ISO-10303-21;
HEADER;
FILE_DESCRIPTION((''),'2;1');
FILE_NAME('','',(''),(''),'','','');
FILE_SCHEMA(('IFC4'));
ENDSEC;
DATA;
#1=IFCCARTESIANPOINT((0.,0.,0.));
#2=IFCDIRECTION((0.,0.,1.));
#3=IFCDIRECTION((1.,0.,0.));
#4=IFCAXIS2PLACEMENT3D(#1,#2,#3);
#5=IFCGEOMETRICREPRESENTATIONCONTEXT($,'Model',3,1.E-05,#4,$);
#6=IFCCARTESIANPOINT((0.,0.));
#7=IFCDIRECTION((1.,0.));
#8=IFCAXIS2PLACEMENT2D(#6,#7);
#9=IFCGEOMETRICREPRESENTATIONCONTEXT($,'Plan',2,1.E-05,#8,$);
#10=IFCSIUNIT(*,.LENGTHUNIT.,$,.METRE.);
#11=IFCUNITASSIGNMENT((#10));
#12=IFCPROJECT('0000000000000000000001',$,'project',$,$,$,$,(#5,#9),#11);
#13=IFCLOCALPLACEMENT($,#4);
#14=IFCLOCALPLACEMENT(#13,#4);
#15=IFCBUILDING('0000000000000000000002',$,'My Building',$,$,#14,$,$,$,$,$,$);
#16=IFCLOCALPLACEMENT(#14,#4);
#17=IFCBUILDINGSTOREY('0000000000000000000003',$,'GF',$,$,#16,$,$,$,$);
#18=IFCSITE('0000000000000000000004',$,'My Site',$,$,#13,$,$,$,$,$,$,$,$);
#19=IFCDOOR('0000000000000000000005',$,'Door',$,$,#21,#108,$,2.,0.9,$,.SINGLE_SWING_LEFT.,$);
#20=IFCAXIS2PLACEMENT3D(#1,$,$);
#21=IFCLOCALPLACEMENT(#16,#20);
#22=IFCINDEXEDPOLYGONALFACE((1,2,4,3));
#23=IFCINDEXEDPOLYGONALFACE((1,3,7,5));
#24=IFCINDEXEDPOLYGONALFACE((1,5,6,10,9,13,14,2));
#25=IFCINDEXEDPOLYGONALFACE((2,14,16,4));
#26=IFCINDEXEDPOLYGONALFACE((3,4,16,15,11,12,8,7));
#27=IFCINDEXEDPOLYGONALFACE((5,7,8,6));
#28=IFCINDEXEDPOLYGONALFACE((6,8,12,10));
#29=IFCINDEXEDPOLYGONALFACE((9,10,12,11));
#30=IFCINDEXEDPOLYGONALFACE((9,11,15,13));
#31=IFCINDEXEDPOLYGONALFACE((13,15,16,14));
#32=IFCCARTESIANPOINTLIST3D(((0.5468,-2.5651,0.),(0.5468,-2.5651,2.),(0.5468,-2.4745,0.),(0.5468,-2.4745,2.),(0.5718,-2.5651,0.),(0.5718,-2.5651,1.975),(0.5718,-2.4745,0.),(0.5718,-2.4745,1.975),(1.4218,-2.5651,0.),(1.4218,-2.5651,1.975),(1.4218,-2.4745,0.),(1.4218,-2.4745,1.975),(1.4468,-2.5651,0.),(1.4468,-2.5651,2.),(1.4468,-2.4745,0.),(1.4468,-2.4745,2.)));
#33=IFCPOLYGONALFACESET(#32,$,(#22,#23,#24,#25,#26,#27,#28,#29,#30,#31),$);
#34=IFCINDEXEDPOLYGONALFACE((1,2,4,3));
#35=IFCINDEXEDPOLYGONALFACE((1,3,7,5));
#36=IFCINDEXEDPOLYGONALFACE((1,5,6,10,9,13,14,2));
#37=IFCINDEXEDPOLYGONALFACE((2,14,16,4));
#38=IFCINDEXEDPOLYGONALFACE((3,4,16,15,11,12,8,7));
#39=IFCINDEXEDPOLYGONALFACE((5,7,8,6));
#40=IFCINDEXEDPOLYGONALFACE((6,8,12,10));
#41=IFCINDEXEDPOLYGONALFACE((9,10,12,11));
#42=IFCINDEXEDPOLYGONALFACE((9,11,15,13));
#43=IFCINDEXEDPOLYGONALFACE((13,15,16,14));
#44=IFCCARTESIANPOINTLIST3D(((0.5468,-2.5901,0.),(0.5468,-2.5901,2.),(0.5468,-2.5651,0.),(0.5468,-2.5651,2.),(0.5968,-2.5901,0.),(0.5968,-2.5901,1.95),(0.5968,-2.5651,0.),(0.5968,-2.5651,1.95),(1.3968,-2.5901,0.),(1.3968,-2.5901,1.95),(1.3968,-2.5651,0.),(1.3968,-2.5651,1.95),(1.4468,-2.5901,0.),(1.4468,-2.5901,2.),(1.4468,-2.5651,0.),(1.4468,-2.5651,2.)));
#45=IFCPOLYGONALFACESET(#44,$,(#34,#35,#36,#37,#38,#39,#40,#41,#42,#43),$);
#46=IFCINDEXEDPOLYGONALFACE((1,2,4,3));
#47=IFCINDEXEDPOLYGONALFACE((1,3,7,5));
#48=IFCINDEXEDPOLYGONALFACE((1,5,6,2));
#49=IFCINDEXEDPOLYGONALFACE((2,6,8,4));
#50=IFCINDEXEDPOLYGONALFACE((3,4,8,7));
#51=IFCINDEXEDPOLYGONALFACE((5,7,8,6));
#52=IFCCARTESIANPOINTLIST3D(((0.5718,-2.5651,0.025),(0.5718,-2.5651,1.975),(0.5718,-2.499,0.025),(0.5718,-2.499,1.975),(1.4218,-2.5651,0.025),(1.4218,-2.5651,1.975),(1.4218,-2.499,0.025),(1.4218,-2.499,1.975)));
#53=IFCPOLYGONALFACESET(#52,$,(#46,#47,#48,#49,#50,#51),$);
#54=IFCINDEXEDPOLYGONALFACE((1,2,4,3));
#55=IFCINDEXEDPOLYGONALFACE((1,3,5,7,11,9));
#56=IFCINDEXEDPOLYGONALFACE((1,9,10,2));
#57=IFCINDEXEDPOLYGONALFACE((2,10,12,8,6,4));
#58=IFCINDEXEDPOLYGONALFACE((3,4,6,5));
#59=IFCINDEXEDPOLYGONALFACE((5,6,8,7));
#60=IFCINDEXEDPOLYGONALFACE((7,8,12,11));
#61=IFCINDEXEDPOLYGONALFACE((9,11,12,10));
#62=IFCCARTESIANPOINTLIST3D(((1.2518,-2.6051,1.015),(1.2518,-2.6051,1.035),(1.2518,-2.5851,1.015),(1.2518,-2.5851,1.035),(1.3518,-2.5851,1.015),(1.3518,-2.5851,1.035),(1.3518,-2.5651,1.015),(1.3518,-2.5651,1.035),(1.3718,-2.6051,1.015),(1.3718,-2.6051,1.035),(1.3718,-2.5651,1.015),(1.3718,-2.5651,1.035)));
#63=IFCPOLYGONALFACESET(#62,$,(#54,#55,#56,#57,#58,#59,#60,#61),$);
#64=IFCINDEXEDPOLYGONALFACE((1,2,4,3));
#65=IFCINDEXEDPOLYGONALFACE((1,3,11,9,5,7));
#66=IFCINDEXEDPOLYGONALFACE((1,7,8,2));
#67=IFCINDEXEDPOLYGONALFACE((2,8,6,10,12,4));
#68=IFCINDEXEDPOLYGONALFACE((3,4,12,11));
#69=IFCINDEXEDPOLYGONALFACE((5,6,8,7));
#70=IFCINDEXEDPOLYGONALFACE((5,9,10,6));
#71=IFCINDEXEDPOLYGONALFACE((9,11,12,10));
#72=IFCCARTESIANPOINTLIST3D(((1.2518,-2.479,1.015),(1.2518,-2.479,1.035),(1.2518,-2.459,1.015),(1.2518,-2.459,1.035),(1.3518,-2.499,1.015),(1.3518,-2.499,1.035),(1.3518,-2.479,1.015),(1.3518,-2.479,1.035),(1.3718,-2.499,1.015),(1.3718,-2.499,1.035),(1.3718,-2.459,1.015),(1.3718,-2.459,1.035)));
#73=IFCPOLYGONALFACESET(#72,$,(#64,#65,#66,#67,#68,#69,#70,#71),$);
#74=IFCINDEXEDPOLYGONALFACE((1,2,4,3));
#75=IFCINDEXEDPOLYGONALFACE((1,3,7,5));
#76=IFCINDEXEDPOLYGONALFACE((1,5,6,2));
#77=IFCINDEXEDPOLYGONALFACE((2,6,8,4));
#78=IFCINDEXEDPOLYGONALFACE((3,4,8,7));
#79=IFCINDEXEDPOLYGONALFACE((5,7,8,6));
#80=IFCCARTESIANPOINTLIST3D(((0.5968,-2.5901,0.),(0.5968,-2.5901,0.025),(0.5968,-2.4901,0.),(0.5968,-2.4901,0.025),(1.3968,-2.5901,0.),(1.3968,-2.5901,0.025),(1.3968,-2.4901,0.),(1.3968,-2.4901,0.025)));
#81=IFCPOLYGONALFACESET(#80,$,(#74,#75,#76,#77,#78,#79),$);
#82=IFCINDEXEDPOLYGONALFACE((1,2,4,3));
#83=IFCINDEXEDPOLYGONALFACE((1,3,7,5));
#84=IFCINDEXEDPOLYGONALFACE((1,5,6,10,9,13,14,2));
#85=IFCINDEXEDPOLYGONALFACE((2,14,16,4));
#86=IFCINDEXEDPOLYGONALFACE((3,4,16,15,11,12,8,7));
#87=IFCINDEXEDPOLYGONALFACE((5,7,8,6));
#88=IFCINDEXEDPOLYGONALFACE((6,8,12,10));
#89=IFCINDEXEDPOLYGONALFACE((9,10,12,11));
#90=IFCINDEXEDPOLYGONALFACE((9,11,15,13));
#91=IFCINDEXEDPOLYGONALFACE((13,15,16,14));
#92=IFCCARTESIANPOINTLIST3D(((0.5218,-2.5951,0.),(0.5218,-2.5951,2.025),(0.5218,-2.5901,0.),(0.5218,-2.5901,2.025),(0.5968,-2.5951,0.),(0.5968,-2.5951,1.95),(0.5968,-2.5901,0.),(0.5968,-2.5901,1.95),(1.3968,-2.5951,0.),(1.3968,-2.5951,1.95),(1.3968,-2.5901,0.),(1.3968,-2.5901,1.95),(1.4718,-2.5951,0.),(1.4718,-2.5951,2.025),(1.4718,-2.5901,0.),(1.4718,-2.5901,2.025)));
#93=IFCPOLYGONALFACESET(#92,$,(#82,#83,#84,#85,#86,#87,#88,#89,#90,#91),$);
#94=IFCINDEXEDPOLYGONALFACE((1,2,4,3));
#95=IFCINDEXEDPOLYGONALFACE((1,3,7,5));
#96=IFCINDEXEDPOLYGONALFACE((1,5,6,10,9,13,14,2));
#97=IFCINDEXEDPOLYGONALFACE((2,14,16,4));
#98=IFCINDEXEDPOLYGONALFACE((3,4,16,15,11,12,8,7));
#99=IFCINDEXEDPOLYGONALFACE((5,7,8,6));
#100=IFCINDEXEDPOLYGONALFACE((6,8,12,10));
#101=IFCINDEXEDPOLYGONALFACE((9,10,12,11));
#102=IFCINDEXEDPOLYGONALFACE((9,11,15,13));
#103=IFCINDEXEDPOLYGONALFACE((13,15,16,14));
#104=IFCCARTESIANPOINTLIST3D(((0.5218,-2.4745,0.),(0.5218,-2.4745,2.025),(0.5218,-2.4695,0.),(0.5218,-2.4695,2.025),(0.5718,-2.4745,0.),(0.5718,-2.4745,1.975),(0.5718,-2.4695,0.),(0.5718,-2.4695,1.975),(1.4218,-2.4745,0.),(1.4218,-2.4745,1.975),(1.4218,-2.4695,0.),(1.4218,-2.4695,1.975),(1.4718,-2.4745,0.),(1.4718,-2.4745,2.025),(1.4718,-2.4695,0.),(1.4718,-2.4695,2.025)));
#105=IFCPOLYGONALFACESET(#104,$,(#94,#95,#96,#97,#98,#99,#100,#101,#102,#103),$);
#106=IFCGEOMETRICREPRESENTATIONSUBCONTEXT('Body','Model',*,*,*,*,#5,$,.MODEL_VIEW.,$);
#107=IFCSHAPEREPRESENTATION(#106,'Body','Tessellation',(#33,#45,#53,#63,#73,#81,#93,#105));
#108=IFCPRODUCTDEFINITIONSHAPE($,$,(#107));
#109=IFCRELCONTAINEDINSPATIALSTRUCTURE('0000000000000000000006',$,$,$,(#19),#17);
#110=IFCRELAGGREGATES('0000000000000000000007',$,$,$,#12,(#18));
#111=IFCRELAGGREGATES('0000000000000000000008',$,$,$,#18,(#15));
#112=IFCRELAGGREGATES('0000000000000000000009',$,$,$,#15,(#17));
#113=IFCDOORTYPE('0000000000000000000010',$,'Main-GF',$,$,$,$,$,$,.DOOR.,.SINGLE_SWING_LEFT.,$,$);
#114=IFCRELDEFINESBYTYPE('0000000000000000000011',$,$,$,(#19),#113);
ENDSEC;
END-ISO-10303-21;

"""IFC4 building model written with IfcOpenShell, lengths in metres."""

from ifc_helpers import new_model, entity, si_unit, frame, origin_with_axes, origin_2d_with_axis, place, context, subcontext, project, spatial, line, indexed_curve, outline, extrude, shape, source, transform, mapped, type_object, type_shapes, element, save


model = new_model("IFC4")

# Units and contexts
model_context = context("Model", 3, precision=1e-05, world=origin_with_axes())
plan_context = context("Plan", 2, precision=1e-05, world=origin_2d_with_axis())
body_context_1 = subcontext(model_context, "Body", "Model", "MODEL_VIEW")
body_context_2 = subcontext(plan_context, "Body", "Plan", "PLAN_VIEW")
ifc_project = project(units=[si_unit("LENGTHUNIT", "METRE")], contexts=[model_context, plan_context])

# Site, building, storey
site_placement = place(None, origin_with_axes())
site = spatial("IfcSite", under=ifc_project, at=site_placement, Name="My Site")
building_placement = place(site_placement, origin_with_axes())
building = spatial("IfcBuilding", under=site, at=building_placement, Name="My Building")
storey_placement = place(building_placement, origin_with_axes())
storey = spatial("IfcBuildingStorey", under=building, at=storey_placement, Name="GF")

# Door
door_type_1 = type_object("IfcDoorType", Name="Main-GF", OperationType="SINGLE_SWING_LEFT", PredefinedType="DOOR")
shared_shape_1 = source(origin_with_axes(), body_context_1, "Body", "SweptSolid", [
    extrude(outline(indexed_curve([(0.0, 0.0), (0.0, 2.0), (0.9, 2.0), (0.9, 0.0), (0.875, 0.0), (0.875, 1.975), (0.025, 1.975), (0.025, 0.0)], segments=[line(1, 2, 3, 4, 5, 6, 7, 8, 1)])), frame((0.0, 0.025, 0.0), z_axis=(0.0, -1.0, 0.0), x_axis=(1.0, 0.0, 0.0)), (0.0, 0.0, -1.0), 0.0906),
    extrude(outline(indexed_curve([(0.0, 0.0), (0.0, 2.0), (0.9, 2.0), (0.9, 0.0), (0.85, 0.0), (0.85, 1.95), (0.05, 1.95), (0.05, 0.0)], segments=[line(1, 2, 3, 4, 5, 6, 7, 8, 1)])), frame((0.0, 0.0, 0.0), z_axis=(0.0, -1.0, 0.0), x_axis=(1.0, 0.0, 0.0)), (0.0, 0.0, -1.0), 0.025),
    extrude(outline(indexed_curve([(0.0, 0.0), (0.85, 0.0), (0.85, 0.0661), (0.0, 0.0661)], segments=[line(1, 2, 3, 4, 1)])), frame((0.025, 0.025, 0.025), z_axis=(0.0, 0.0, 1.0), x_axis=(1.0, 0.0, 0.0)), (0.0, 0.0, 1.0), 1.95),
    extrude(outline(indexed_curve([(0.0, 0.0), (0.0, -0.04), (-0.12, -0.04), (-0.12, -0.02), (-0.02, -0.02), (-0.02, 0.0)], segments=[line(1, 2, 3, 4, 5, 6, 1)])), frame((0.825, 0.025, 1.015), z_axis=(0.0, 0.0, 1.0), x_axis=(1.0, 0.0, 0.0)), (0.0, 0.0, 1.0), 0.02),
    extrude(outline(indexed_curve([(0.0, 0.0), (0.0, 0.04), (-0.12, 0.04), (-0.12, 0.02), (-0.02, 0.02), (-0.02, 0.0)], segments=[line(1, 2, 3, 4, 5, 6, 1)])), frame((0.825, 0.0911, 1.015), z_axis=(0.0, 0.0, 1.0), x_axis=(1.0, 0.0, 0.0)), (0.0, 0.0, 1.0), 0.02),
    extrude(outline(indexed_curve([(0.0, 0.0), (0.8, 0.0), (0.8, 0.1), (0.0, 0.1)], segments=[line(1, 2, 3, 4, 1)])), frame((0.05, 0.0, 0.0), z_axis=(0.0, 0.0, 1.0), x_axis=(1.0, 0.0, 0.0)), (0.0, 0.0, 1.0), 0.025),
    extrude(outline(indexed_curve([(0.0, 0.0), (0.0, 2.025), (0.95, 2.025), (0.95, 0.0), (0.875, 0.0), (0.875, 1.95), (0.075, 1.95), (0.075, 0.0)], segments=[line(1, 2, 3, 4, 5, 6, 7, 8, 1)])), frame((-0.025, -0.005, 0.0), z_axis=(0.0, -1.0, 0.0), x_axis=(1.0, 0.0, 0.0)), (0.0, 0.0, -1.0), 0.005),
    extrude(outline(indexed_curve([(0.0, 0.0), (0.0, 2.025), (0.95, 2.025), (0.95, 0.0), (0.9, 0.0), (0.9, 1.975), (0.05, 1.975), (0.05, 0.0)], segments=[line(1, 2, 3, 4, 5, 6, 7, 8, 1)])), frame((-0.025, 0.1156, 0.0), z_axis=(0.0, -1.0, 0.0), x_axis=(1.0, 0.0, 0.0)), (0.0, 0.0, -1.0), 0.005),
])
shared_shape_2 = source(origin_with_axes(), body_context_2, "Body", "Curve2D", [
    entity("IfcIndexedPolyCurve", entity("IfcCartesianPointList2D", [[0.0, 0.0], [0.0, 0.1156], [0.025, 0.1156], [0.025, 0.025], [0.05, 0.025], [0.05, 0.0]]), [entity("IfcLineIndex", [1, 2, 3, 4, 5, 6, 1])]),
    entity("IfcIndexedPolyCurve", entity("IfcCartesianPointList2D", [[0.9, 0.0], [0.9, 0.1156], [0.875, 0.1156], [0.875, 0.025], [0.85, 0.025], [0.85, 0.0]]), [entity("IfcLineIndex", [1, 2, 3, 4, 5, 6, 1])]),
    entity("IfcTrimmedCurve", entity("IfcEllipse", entity("IfcAxis2Placement2D", entity("IfcCartesianPoint", [0.0911, 0.1156]), entity("IfcDirection", [1.0, 0.0])), 0.7839, 0.85), [entity("IfcCartesianPoint", [0.875, 0.1156])], [entity("IfcCartesianPoint", [0.0911, 0.9656])], True, "CARTESIAN"),
    entity("IfcIndexedPolyCurve", entity("IfcCartesianPointList2D", [[0.025, 0.1156], [0.0911, 0.1156], [0.0911, 0.9656], [0.025, 0.9656]]), [entity("IfcLineIndex", [1, 2, 3, 4, 1])]),
])
type_shapes(door_type_1, [shared_shape_1, shared_shape_2])
door_1_placement = place(storey_placement, frame((0.5468, -2.5901, 0.0), z_axis=(0.0, 0.0, 1.0), x_axis=(1.0, 0.0, 0.0)))
element("IfcDoor", 1, at=door_1_placement, inside=storey, type_object=door_type_1, Name="Door", OperationType="SINGLE_SWING_LEFT", OverallHeight=2.0, OverallWidth=0.9, shapes=[
    shape(body_context_1, "Body", "MappedRepresentation", [mapped(shared_shape_1, transform((0.0, 0.0, 0.0), x_axis=(1.0, 0.0, 0.0), y_axis=(0.0, 1.0, 0.0), z_axis=(0.0, 0.0, 1.0), scale=1.0))]),
    shape(body_context_2, "Body", "MappedRepresentation", [mapped(shared_shape_2, transform((0.0, 0.0, 0.0), x_axis=(1.0, 0.0, 0.0), y_axis=(0.0, 1.0, 0.0), z_axis=(0.0, 0.0, 1.0), scale=1.0))]),
])

save(model, "model.ifc")
